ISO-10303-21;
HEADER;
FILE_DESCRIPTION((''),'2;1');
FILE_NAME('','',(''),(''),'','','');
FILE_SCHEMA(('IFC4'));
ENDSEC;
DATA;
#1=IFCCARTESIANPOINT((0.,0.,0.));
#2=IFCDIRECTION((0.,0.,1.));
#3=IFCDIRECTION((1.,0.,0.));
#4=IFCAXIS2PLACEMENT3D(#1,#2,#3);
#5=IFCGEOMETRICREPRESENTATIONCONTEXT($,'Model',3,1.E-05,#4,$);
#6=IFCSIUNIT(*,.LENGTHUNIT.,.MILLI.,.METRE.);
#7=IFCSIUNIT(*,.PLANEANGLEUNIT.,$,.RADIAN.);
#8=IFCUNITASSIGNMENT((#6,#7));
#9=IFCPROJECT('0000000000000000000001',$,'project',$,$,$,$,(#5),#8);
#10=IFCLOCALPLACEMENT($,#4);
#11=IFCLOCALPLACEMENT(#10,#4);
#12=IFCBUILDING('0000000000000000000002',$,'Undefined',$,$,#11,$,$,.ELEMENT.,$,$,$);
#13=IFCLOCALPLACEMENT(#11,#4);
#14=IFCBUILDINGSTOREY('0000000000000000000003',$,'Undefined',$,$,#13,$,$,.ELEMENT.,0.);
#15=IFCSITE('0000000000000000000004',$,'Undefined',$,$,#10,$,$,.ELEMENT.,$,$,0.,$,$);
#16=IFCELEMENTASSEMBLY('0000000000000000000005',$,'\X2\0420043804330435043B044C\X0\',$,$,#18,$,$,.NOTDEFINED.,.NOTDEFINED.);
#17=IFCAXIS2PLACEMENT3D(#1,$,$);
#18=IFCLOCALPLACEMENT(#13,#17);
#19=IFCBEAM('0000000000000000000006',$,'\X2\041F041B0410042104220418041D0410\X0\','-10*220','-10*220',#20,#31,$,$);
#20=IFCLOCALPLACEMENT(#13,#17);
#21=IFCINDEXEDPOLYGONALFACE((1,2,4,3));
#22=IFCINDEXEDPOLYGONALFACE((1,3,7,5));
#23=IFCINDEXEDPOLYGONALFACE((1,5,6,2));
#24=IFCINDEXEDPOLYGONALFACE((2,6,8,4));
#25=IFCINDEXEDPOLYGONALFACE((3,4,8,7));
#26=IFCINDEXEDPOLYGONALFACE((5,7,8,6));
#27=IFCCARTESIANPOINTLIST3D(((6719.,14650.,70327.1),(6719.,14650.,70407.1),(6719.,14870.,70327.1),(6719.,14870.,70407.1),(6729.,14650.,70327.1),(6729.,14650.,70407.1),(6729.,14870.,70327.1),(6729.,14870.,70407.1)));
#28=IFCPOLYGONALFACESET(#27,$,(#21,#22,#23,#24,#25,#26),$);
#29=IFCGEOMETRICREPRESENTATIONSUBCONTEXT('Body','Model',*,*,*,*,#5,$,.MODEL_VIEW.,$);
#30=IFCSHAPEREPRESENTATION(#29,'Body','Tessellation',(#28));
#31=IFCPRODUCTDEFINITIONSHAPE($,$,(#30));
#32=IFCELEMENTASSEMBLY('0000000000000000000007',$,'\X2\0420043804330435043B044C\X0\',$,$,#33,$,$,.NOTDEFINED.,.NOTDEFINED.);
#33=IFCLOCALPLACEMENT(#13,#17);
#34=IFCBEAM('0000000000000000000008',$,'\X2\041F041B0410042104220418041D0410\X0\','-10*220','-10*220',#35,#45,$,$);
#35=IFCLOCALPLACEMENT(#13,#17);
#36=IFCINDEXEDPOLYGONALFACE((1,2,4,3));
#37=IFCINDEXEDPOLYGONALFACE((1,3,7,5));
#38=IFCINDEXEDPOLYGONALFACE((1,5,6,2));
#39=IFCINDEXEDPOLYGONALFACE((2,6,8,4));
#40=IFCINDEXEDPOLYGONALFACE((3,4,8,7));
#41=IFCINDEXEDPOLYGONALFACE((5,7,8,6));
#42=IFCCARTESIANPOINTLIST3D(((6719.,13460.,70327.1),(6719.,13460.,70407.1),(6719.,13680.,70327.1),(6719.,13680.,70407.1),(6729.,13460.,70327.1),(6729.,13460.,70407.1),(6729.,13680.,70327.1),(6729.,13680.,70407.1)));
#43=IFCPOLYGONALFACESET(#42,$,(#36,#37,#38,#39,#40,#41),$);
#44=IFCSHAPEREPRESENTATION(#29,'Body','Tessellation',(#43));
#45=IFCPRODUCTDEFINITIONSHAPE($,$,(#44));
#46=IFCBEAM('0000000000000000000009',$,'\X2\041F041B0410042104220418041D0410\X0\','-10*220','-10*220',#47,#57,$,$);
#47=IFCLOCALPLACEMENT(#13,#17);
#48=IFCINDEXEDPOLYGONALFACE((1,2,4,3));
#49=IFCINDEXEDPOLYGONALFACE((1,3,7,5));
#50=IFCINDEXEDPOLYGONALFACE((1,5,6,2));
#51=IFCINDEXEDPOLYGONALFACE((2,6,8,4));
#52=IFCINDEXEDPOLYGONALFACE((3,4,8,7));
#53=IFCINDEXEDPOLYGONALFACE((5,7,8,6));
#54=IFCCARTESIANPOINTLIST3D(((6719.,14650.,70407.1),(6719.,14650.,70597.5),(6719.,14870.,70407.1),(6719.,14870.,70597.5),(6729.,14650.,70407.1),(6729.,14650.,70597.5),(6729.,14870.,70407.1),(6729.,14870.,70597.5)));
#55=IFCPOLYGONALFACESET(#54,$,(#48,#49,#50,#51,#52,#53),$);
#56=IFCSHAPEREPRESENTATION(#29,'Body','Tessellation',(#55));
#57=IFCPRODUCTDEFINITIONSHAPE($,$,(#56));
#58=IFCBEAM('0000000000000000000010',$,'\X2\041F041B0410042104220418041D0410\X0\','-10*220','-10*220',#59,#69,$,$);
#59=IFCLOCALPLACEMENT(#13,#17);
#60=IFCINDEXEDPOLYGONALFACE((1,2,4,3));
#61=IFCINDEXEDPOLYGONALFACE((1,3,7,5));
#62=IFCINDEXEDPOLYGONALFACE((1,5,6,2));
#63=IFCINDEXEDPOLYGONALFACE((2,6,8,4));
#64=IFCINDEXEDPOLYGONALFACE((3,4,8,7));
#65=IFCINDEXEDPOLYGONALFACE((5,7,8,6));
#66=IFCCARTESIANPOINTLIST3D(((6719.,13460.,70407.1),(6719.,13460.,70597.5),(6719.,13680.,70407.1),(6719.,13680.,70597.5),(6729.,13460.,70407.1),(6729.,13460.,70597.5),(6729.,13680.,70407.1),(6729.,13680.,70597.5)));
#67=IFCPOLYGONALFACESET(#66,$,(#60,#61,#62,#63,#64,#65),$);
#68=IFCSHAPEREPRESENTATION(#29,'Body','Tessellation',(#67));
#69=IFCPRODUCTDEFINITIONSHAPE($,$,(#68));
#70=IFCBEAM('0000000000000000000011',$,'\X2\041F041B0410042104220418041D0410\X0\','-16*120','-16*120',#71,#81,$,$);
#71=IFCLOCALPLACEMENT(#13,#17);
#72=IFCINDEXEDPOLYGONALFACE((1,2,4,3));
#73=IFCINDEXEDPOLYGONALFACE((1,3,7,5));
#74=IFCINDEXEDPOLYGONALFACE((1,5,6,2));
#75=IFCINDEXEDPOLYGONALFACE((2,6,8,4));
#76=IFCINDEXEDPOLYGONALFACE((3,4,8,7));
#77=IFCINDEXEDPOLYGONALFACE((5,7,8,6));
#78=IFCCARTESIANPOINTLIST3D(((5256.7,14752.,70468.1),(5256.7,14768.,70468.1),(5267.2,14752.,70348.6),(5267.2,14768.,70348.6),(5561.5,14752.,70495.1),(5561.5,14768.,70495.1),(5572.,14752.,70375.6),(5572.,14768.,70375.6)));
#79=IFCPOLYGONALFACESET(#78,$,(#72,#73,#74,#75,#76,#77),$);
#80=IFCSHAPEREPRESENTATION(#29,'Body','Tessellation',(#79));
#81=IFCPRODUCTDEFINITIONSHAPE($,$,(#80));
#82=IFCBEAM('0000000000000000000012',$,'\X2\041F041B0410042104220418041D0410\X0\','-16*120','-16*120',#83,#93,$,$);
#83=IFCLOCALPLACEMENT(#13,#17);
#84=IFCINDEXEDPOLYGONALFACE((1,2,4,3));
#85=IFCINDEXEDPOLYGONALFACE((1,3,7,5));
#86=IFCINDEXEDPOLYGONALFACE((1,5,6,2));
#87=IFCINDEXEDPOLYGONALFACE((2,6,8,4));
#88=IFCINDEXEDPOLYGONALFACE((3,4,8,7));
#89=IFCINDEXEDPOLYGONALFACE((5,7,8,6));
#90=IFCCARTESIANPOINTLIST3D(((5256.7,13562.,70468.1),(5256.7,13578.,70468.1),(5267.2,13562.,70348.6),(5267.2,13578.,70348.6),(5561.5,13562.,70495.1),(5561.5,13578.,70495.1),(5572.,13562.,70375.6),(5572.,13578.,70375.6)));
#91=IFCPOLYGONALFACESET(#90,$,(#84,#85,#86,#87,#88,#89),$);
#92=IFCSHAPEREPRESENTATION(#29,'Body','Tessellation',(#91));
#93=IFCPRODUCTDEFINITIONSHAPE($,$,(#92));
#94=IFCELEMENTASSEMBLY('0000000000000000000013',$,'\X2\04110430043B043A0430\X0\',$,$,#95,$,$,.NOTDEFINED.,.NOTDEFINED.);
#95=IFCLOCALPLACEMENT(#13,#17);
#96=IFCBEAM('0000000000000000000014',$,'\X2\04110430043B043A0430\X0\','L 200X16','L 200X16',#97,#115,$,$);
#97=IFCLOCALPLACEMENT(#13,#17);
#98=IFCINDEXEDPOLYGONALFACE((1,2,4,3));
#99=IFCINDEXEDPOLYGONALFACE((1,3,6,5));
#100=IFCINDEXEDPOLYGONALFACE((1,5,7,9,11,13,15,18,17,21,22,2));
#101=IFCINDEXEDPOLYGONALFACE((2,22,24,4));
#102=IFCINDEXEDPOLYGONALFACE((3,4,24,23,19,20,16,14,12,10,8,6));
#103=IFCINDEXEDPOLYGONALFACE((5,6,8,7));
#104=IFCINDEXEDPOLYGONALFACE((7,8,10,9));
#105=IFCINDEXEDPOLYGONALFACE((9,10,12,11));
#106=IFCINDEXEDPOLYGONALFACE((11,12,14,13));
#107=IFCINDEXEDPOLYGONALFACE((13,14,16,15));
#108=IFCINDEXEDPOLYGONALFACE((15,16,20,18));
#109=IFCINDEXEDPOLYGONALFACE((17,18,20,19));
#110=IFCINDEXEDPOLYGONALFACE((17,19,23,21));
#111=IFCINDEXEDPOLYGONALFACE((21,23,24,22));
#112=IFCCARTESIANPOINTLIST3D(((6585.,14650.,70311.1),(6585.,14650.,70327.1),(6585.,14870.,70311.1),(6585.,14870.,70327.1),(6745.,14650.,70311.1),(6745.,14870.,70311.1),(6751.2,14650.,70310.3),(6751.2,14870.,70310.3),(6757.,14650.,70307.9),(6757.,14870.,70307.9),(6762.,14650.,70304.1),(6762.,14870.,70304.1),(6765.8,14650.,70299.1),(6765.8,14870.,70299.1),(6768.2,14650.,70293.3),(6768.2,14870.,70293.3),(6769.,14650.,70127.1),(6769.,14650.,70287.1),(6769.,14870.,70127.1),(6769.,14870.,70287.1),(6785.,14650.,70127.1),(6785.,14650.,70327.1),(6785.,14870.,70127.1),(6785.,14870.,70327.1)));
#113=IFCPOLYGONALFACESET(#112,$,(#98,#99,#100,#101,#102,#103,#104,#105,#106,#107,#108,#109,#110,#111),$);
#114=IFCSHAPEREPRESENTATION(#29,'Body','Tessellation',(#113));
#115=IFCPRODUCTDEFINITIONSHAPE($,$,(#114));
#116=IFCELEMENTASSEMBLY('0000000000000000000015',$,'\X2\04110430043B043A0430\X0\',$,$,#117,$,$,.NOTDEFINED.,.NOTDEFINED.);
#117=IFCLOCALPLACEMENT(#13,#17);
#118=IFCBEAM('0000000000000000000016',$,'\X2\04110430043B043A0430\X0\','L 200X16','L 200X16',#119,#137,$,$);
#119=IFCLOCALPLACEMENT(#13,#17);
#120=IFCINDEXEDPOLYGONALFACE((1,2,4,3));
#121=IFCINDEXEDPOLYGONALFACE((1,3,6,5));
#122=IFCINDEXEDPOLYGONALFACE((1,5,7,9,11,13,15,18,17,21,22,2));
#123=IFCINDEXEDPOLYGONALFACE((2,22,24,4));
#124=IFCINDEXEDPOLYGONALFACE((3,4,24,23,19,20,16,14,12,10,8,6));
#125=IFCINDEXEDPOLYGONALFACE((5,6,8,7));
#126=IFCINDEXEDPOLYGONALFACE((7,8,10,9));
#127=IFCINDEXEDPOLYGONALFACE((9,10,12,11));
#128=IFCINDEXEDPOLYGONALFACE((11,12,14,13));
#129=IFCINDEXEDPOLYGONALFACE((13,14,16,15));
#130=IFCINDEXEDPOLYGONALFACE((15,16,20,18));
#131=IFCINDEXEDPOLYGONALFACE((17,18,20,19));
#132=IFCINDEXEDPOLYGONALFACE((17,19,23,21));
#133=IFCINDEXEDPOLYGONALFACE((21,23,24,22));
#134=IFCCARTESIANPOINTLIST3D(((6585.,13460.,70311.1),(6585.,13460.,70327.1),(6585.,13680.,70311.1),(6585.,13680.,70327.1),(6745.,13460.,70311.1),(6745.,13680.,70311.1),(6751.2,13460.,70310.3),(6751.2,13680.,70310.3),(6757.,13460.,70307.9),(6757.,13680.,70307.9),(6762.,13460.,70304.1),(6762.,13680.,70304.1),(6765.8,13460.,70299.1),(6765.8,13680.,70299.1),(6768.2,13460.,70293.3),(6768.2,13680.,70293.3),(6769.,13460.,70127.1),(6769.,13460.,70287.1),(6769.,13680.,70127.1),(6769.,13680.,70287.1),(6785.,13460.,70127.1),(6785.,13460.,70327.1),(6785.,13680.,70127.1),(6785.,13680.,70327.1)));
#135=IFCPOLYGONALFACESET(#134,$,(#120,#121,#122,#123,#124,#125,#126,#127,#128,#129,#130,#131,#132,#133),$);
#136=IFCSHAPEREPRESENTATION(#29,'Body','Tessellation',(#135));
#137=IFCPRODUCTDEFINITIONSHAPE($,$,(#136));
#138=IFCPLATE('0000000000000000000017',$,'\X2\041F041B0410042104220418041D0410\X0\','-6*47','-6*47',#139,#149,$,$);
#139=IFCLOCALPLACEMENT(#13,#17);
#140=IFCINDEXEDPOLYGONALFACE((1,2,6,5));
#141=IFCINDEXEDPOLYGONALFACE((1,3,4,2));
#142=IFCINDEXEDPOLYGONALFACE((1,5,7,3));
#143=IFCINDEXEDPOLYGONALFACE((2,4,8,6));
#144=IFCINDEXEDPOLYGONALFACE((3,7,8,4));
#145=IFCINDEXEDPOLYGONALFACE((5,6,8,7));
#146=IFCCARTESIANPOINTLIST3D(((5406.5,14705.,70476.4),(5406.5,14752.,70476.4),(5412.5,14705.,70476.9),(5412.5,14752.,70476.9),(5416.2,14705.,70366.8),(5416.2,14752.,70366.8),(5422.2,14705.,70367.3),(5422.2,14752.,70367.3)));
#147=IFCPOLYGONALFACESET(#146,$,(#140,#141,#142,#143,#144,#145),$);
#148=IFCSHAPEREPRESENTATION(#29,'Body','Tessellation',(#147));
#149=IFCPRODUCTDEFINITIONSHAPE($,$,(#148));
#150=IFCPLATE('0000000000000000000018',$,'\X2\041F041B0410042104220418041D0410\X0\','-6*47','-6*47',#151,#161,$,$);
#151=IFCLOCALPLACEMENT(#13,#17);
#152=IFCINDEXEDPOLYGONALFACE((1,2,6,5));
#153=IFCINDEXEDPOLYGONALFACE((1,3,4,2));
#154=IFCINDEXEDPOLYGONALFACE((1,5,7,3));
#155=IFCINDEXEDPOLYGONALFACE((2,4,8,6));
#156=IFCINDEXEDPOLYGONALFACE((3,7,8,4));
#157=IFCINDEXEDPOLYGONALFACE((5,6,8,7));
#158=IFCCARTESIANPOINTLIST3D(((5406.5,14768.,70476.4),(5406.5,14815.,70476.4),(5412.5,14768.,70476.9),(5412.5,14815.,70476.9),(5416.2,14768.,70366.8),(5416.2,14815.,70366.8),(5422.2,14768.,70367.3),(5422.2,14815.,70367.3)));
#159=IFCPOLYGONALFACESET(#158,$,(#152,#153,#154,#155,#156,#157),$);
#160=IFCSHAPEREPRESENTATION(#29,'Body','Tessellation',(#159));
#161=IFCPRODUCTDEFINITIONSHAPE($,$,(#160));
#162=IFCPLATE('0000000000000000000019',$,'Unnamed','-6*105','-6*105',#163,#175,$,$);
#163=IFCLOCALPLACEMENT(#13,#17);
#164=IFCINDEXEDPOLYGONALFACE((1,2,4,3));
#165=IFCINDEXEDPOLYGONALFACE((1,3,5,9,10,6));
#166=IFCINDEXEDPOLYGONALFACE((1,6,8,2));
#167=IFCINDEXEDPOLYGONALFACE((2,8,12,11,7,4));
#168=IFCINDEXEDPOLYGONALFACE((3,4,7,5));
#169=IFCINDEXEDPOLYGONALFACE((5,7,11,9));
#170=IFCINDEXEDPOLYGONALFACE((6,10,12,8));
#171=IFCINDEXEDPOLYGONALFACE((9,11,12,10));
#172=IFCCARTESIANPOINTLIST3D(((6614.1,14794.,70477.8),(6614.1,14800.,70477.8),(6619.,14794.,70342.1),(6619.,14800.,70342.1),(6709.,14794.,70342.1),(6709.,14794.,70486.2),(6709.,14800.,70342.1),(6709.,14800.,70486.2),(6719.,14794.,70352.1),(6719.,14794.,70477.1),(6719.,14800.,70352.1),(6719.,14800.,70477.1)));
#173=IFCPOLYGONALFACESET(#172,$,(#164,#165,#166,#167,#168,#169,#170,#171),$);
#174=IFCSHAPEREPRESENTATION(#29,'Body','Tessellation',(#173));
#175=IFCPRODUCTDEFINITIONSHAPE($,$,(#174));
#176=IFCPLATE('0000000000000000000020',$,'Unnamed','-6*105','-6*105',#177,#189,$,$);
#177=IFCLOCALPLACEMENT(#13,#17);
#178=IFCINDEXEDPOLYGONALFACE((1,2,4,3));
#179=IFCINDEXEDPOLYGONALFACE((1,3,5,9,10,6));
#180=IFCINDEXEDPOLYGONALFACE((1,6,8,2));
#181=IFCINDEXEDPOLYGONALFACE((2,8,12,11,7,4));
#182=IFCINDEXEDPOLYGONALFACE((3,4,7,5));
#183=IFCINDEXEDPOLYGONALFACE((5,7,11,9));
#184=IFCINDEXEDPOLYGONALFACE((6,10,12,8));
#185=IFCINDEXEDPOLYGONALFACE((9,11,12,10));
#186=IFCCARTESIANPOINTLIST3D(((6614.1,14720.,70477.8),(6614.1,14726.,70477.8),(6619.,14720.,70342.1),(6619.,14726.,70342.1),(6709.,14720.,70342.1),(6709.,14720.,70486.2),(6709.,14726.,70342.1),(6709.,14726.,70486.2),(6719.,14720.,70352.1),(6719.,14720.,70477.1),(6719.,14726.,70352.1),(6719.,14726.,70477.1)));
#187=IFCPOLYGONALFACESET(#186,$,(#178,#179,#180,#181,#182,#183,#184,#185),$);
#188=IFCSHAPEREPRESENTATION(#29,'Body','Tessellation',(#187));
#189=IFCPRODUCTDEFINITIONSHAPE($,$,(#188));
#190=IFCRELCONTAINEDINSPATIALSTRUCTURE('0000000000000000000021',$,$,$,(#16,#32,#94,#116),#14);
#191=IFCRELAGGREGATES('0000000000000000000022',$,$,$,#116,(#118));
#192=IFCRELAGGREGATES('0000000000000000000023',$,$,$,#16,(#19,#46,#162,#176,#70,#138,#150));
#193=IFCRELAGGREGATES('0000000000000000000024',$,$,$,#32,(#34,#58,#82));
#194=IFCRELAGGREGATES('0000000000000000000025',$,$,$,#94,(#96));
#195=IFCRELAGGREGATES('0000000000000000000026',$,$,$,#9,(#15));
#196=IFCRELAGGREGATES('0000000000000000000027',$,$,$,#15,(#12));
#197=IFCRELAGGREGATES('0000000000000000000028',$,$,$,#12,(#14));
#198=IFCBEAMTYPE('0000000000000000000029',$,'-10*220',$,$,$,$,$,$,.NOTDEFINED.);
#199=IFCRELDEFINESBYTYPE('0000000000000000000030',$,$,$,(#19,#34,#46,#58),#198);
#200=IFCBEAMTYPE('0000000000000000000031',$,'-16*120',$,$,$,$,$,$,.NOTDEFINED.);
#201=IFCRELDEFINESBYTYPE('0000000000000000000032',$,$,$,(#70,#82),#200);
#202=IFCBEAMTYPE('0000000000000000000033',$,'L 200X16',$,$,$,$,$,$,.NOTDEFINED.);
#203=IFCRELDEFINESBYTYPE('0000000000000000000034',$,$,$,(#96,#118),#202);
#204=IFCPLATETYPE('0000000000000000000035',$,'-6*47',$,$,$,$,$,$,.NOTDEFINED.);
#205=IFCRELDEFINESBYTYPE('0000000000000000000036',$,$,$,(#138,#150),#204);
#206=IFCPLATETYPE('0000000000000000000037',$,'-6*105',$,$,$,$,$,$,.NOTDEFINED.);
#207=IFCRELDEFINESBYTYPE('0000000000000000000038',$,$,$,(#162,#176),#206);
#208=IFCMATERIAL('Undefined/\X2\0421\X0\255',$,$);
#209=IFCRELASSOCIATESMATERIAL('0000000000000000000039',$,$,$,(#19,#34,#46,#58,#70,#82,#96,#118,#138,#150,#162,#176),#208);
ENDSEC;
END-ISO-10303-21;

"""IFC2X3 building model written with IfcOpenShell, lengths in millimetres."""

from ifc_helpers import new_model, si_unit, frame, origin_with_axes, origin_2d_with_axis, place, context, subcontext, project, spatial, polyline, rectangle, l_section, outline, extrude, boolean, material, type_object, element, aggregate, save


model = new_model("IFC2X3")

# Units and contexts
model_context = context("Model", 3, precision=1e-05, world=origin_with_axes())
body_context = subcontext(model_context, "Body", "Model", "MODEL_VIEW")
ifc_project = project(units=[si_unit("LENGTHUNIT", "METRE", prefix="MILLI"), si_unit("PLANEANGLEUNIT", "RADIAN")], contexts=[model_context])

# Site, building, storey
site_placement = place(None, origin_with_axes())
site = spatial("IfcSite", under=ifc_project, at=site_placement, Name="Undefined", CompositionType="ELEMENT", RefElevation=0.0)
building_placement = place(site_placement, origin_with_axes())
building = spatial("IfcBuilding", under=site, at=building_placement, Name="Undefined", CompositionType="ELEMENT")
storey_placement = place(building_placement, origin_with_axes())
storey = spatial("IfcBuildingStorey", under=building, at=storey_placement, Name="Undefined", CompositionType="ELEMENT", Elevation=0.0)

# Element assemblies, beams
assembly_1_placement = place(storey_placement, origin_with_axes())
assembly_1 = element("IfcElementAssembly", 1, at=assembly_1_placement, inside=storey, Name="Ригель", AssemblyPlace="NOTDEFINED", PredefinedType="NOTDEFINED")
ifc_material_1 = material(Name="Undefined/С255")
beam_type_1 = type_object("IfcBeamType", Name="-10*220", PredefinedType="NOTDEFINED")
beam_1_placement = place(assembly_1_placement, frame((6724.0, 14760.0, 70327.1), z_axis=(0.0, 1.0, 0.0), x_axis=(0.0, 0.0, 1.0)))
beam_1 = element("IfcBeam", 2, at=beam_1_placement, type_object=beam_type_1, material=ifc_material_1, Name="ПЛАСТИНА", Description="-10*220", ObjectType="-10*220", context=body_context, shape_type="SweptSolid", body=[
    extrude(rectangle(XDim=10.0, YDim=220.0, at=origin_2d_with_axis()), frame((80.0, 0.0, 0.0), z_axis=(-1.0, 0.0, 0.0), x_axis=(0.0, -1.0, 0.0)), (0.0, 0.0, 1.0), 80.0),
])
assembly_2_placement = place(storey_placement, origin_with_axes())
assembly_2 = element("IfcElementAssembly", 3, at=assembly_2_placement, inside=storey, Name="Ригель", AssemblyPlace="NOTDEFINED", PredefinedType="NOTDEFINED")
beam_2_placement = place(assembly_2_placement, frame((6724.0, 13570.0, 70327.1), z_axis=(0.0, 1.0, 0.0), x_axis=(0.0, 0.0, 1.0)))
beam_2 = element("IfcBeam", 4, at=beam_2_placement, type_object=beam_type_1, material=ifc_material_1, Name="ПЛАСТИНА", Description="-10*220", ObjectType="-10*220", context=body_context, shape_type="SweptSolid", body=[
    extrude(rectangle(XDim=10.0, YDim=220.0, at=origin_2d_with_axis()), frame((80.0, 0.0, 0.0), z_axis=(-1.0, 0.0, 0.0), x_axis=(0.0, -1.0, 0.0)), (0.0, 0.0, 1.0), 80.0),
])

# Beams
beam_3_placement = place(assembly_1_placement, frame((6724.0, 14760.0, 70407.1), z_axis=(0.0, 1.0, 0.0), x_axis=(0.0, 0.0, 1.0)))
beam_3 = element("IfcBeam", 5, at=beam_3_placement, type_object=beam_type_1, material=ifc_material_1, Name="ПЛАСТИНА", Description="-10*220", ObjectType="-10*220", context=body_context, shape_type="SweptSolid", body=[
    extrude(rectangle(XDim=10.0, YDim=220.0, at=origin_2d_with_axis()), frame((190.4, 0.0, 0.0), z_axis=(-1.0, 0.0, 0.0), x_axis=(0.0, -1.0, 0.0)), (0.0, 0.0, 1.0), 190.4),
])
beam_4_placement = place(assembly_2_placement, frame((6724.0, 13570.0, 70407.1), z_axis=(0.0, 1.0, 0.0), x_axis=(0.0, 0.0, 1.0)))
beam_4 = element("IfcBeam", 6, at=beam_4_placement, type_object=beam_type_1, material=ifc_material_1, Name="ПЛАСТИНА", Description="-10*220", ObjectType="-10*220", context=body_context, shape_type="SweptSolid", body=[
    extrude(rectangle(XDim=10.0, YDim=220.0, at=origin_2d_with_axis()), frame((190.4, 0.0, 0.0), z_axis=(-1.0, 0.0, 0.0), x_axis=(0.0, -1.0, 0.0)), (0.0, 0.0, 1.0), 190.4),
])
beam_type_2 = type_object("IfcBeamType", Name="-16*120", PredefinedType="NOTDEFINED")
beam_5_placement = place(assembly_1_placement, frame((5261.9, 14760.0, 70408.4), z_axis=(0.088152, 0.0, -0.996107), x_axis=(0.996107, 0.0, 0.088152)))
beam_5 = element("IfcBeam", 7, at=beam_5_placement, type_object=beam_type_2, material=ifc_material_1, Name="ПЛАСТИНА", Description="-16*120", ObjectType="-16*120", context=body_context, shape_type="SweptSolid", body=[
    extrude(rectangle(XDim=16.0, YDim=120.0, at=origin_2d_with_axis()), frame((306.0, 0.0, 0.0), z_axis=(-1.0, 0.0, 0.0), x_axis=(0.0, -1.0, 0.0)), (0.0, 0.0, 1.0), 306.0),
])
beam_6_placement = place(assembly_2_placement, frame((5261.9, 13570.0, 70408.4), z_axis=(0.088152, 0.0, -0.996107), x_axis=(0.996107, 0.0, 0.088152)))
beam_6 = element("IfcBeam", 8, at=beam_6_placement, type_object=beam_type_2, material=ifc_material_1, Name="ПЛАСТИНА", Description="-16*120", ObjectType="-16*120", context=body_context, shape_type="SweptSolid", body=[
    extrude(rectangle(XDim=16.0, YDim=120.0, at=origin_2d_with_axis()), frame((306.0, 0.0, 0.0), z_axis=(-1.0, 0.0, 0.0), x_axis=(0.0, -1.0, 0.0)), (0.0, 0.0, 1.0), 306.0),
])

# Element assemblies, beams
assembly_3_placement = place(storey_placement, origin_with_axes())
assembly_3 = element("IfcElementAssembly", 9, at=assembly_3_placement, inside=storey, Name="Балка", AssemblyPlace="NOTDEFINED", PredefinedType="NOTDEFINED")
beam_type_3 = type_object("IfcBeamType", Name="L 200X16", PredefinedType="NOTDEFINED")
beam_7_placement = place(assembly_3_placement, frame((6685.0, 14870.0, 70227.1), z_axis=(-1.0, 0.0, 0.0), x_axis=(0.0, -1.0, 0.0)))
beam_7 = element("IfcBeam", 10, at=beam_7_placement, type_object=beam_type_3, material=ifc_material_1, Name="Балка", Description="L 200X16", ObjectType="L 200X16", context=body_context, shape_type="SweptSolid", body=[
    extrude(l_section(Depth=200.0, Width=200.0, Thickness=16.0, FilletRadius=24.0, at=origin_2d_with_axis()), frame((220.0, 0.0, 0.0), z_axis=(-1.0, 0.0, 0.0), x_axis=(0.0, -1.0, 0.0)), (0.0, 0.0, 1.0), 220.0),
])
assembly_4_placement = place(storey_placement, origin_with_axes())
assembly_4 = element("IfcElementAssembly", 11, at=assembly_4_placement, inside=storey, Name="Балка", AssemblyPlace="NOTDEFINED", PredefinedType="NOTDEFINED")
beam_8_placement = place(assembly_4_placement, frame((6685.0, 13680.0, 70227.1), z_axis=(-1.0, 0.0, 0.0), x_axis=(0.0, -1.0, 0.0)))
beam_8 = element("IfcBeam", 12, at=beam_8_placement, type_object=beam_type_3, material=ifc_material_1, Name="Балка", Description="L 200X16", ObjectType="L 200X16", context=body_context, shape_type="SweptSolid", body=[
    extrude(l_section(Depth=200.0, Width=200.0, Thickness=16.0, FilletRadius=24.0, at=origin_2d_with_axis()), frame((220.0, 0.0, 0.0), z_axis=(-1.0, 0.0, 0.0), x_axis=(0.0, -1.0, 0.0)), (0.0, 0.0, 1.0), 220.0),
])
aggregate(assembly_4, [beam_8])

# Plates
plate_type_1 = type_object("IfcPlateType", Name="-6*47", PredefinedType="NOTDEFINED")
plate_1_placement = place(assembly_1_placement, frame((5419.2, 14705.0, 70367.1), z_axis=(-0.996107, 0.0, -0.088152), x_axis=(-0.088152, 0.0, 0.996107)))
plate_1 = element("IfcPlate", 13, at=plate_1_placement, type_object=plate_type_1, material=ifc_material_1, Name="ПЛАСТИНА", Description="-6*47", ObjectType="-6*47", context=body_context, shape_type="CSG", body=[
    boolean("DIFFERENCE", extrude(outline(polyline([(0.0, 0.0), (110.0, 0.0), (110.0, 110.0), (0.0, 110.0), (0.0, 0.0)])), frame((0.0, 0.0, -3.0), z_axis=(0.0, 0.0, 1.0), x_axis=(1.0, 0.0, 0.0)), (0.0, 0.0, 1.0), 6.0), extrude(rectangle(XDim=26.0, YDim=130.0, at=origin_2d_with_axis()), frame((55.0, 47.0, 0.0), z_axis=(0.0, 1.0, 0.0), x_axis=(0.0, 0.0, -1.0)), (0.0, 0.0, 1.0), 66.0)),
])
plate_2_placement = place(assembly_1_placement, frame((5419.2, 14705.0, 70367.1), z_axis=(-0.996107, 0.0, -0.088152), x_axis=(-0.088152, 0.0, 0.996107)))
plate_2 = element("IfcPlate", 14, at=plate_2_placement, type_object=plate_type_1, material=ifc_material_1, Name="ПЛАСТИНА", Description="-6*47", ObjectType="-6*47", context=body_context, shape_type="CSG", body=[
    boolean("DIFFERENCE", extrude(outline(polyline([(0.0, 0.0), (110.0, 0.0), (110.0, 110.0), (0.0, 110.0), (0.0, 0.0)])), frame((0.0, 0.0, -3.0), z_axis=(0.0, 0.0, 1.0), x_axis=(1.0, 0.0, 0.0)), (0.0, 0.0, 1.0), 6.0), extrude(rectangle(XDim=26.0, YDim=130.0, at=origin_2d_with_axis()), frame((55.0, -3.0, 0.0), z_axis=(0.0, 1.0, 0.0), x_axis=(0.0, 0.0, -1.0)), (0.0, 0.0, 1.0), 66.0)),
])
plate_type_2 = type_object("IfcPlateType", Name="-6*105", PredefinedType="NOTDEFINED")
plate_3_placement = place(assembly_1_placement, frame((6719.0, 14797.0, 70342.1), z_axis=(0.0, -1.0, 0.0), x_axis=(0.0, 0.0, 1.0)))
plate_3 = element("IfcPlate", 15, at=plate_3_placement, type_object=plate_type_2, material=ifc_material_1, Name="Unnamed", Description="-6*105", ObjectType="-6*105", context=body_context, shape_type="SweptSolid", body=[
    extrude(outline(polyline([(0.0, 10.0), (10.0, 0.0), (135.0, 0.0), (144.1, 10.0), (135.7, 104.9), (0.0, 100.0), (0.0, 10.0)])), frame((0.0, 0.0, -3.0), z_axis=(0.0, 0.0, 1.0), x_axis=(1.0, 0.0, 0.0)), (0.0, 0.0, 1.0), 6.0),
])
plate_4_placement = place(assembly_1_placement, frame((6719.0, 14723.0, 70342.1), z_axis=(0.0, -1.0, 0.0), x_axis=(0.0, 0.0, 1.0)))
plate_4 = element("IfcPlate", 16, at=plate_4_placement, type_object=plate_type_2, material=ifc_material_1, Name="Unnamed", Description="-6*105", ObjectType="-6*105", context=body_context, shape_type="SweptSolid", body=[
    extrude(outline(polyline([(0.0, 10.0), (10.0, 0.0), (135.0, 0.0), (144.1, 10.0), (135.7, 104.9), (0.0, 100.0), (0.0, 10.0)])), frame((0.0, 0.0, -3.0), z_axis=(0.0, 0.0, 1.0), x_axis=(1.0, 0.0, 0.0)), (0.0, 0.0, 1.0), 6.0),
])

aggregate(assembly_1, [beam_1, beam_3, plate_3, plate_4, beam_5, plate_1, plate_2])
aggregate(assembly_2, [beam_2, beam_4, beam_6])

aggregate(assembly_3, [beam_7])

save(model, "model.ifc")
